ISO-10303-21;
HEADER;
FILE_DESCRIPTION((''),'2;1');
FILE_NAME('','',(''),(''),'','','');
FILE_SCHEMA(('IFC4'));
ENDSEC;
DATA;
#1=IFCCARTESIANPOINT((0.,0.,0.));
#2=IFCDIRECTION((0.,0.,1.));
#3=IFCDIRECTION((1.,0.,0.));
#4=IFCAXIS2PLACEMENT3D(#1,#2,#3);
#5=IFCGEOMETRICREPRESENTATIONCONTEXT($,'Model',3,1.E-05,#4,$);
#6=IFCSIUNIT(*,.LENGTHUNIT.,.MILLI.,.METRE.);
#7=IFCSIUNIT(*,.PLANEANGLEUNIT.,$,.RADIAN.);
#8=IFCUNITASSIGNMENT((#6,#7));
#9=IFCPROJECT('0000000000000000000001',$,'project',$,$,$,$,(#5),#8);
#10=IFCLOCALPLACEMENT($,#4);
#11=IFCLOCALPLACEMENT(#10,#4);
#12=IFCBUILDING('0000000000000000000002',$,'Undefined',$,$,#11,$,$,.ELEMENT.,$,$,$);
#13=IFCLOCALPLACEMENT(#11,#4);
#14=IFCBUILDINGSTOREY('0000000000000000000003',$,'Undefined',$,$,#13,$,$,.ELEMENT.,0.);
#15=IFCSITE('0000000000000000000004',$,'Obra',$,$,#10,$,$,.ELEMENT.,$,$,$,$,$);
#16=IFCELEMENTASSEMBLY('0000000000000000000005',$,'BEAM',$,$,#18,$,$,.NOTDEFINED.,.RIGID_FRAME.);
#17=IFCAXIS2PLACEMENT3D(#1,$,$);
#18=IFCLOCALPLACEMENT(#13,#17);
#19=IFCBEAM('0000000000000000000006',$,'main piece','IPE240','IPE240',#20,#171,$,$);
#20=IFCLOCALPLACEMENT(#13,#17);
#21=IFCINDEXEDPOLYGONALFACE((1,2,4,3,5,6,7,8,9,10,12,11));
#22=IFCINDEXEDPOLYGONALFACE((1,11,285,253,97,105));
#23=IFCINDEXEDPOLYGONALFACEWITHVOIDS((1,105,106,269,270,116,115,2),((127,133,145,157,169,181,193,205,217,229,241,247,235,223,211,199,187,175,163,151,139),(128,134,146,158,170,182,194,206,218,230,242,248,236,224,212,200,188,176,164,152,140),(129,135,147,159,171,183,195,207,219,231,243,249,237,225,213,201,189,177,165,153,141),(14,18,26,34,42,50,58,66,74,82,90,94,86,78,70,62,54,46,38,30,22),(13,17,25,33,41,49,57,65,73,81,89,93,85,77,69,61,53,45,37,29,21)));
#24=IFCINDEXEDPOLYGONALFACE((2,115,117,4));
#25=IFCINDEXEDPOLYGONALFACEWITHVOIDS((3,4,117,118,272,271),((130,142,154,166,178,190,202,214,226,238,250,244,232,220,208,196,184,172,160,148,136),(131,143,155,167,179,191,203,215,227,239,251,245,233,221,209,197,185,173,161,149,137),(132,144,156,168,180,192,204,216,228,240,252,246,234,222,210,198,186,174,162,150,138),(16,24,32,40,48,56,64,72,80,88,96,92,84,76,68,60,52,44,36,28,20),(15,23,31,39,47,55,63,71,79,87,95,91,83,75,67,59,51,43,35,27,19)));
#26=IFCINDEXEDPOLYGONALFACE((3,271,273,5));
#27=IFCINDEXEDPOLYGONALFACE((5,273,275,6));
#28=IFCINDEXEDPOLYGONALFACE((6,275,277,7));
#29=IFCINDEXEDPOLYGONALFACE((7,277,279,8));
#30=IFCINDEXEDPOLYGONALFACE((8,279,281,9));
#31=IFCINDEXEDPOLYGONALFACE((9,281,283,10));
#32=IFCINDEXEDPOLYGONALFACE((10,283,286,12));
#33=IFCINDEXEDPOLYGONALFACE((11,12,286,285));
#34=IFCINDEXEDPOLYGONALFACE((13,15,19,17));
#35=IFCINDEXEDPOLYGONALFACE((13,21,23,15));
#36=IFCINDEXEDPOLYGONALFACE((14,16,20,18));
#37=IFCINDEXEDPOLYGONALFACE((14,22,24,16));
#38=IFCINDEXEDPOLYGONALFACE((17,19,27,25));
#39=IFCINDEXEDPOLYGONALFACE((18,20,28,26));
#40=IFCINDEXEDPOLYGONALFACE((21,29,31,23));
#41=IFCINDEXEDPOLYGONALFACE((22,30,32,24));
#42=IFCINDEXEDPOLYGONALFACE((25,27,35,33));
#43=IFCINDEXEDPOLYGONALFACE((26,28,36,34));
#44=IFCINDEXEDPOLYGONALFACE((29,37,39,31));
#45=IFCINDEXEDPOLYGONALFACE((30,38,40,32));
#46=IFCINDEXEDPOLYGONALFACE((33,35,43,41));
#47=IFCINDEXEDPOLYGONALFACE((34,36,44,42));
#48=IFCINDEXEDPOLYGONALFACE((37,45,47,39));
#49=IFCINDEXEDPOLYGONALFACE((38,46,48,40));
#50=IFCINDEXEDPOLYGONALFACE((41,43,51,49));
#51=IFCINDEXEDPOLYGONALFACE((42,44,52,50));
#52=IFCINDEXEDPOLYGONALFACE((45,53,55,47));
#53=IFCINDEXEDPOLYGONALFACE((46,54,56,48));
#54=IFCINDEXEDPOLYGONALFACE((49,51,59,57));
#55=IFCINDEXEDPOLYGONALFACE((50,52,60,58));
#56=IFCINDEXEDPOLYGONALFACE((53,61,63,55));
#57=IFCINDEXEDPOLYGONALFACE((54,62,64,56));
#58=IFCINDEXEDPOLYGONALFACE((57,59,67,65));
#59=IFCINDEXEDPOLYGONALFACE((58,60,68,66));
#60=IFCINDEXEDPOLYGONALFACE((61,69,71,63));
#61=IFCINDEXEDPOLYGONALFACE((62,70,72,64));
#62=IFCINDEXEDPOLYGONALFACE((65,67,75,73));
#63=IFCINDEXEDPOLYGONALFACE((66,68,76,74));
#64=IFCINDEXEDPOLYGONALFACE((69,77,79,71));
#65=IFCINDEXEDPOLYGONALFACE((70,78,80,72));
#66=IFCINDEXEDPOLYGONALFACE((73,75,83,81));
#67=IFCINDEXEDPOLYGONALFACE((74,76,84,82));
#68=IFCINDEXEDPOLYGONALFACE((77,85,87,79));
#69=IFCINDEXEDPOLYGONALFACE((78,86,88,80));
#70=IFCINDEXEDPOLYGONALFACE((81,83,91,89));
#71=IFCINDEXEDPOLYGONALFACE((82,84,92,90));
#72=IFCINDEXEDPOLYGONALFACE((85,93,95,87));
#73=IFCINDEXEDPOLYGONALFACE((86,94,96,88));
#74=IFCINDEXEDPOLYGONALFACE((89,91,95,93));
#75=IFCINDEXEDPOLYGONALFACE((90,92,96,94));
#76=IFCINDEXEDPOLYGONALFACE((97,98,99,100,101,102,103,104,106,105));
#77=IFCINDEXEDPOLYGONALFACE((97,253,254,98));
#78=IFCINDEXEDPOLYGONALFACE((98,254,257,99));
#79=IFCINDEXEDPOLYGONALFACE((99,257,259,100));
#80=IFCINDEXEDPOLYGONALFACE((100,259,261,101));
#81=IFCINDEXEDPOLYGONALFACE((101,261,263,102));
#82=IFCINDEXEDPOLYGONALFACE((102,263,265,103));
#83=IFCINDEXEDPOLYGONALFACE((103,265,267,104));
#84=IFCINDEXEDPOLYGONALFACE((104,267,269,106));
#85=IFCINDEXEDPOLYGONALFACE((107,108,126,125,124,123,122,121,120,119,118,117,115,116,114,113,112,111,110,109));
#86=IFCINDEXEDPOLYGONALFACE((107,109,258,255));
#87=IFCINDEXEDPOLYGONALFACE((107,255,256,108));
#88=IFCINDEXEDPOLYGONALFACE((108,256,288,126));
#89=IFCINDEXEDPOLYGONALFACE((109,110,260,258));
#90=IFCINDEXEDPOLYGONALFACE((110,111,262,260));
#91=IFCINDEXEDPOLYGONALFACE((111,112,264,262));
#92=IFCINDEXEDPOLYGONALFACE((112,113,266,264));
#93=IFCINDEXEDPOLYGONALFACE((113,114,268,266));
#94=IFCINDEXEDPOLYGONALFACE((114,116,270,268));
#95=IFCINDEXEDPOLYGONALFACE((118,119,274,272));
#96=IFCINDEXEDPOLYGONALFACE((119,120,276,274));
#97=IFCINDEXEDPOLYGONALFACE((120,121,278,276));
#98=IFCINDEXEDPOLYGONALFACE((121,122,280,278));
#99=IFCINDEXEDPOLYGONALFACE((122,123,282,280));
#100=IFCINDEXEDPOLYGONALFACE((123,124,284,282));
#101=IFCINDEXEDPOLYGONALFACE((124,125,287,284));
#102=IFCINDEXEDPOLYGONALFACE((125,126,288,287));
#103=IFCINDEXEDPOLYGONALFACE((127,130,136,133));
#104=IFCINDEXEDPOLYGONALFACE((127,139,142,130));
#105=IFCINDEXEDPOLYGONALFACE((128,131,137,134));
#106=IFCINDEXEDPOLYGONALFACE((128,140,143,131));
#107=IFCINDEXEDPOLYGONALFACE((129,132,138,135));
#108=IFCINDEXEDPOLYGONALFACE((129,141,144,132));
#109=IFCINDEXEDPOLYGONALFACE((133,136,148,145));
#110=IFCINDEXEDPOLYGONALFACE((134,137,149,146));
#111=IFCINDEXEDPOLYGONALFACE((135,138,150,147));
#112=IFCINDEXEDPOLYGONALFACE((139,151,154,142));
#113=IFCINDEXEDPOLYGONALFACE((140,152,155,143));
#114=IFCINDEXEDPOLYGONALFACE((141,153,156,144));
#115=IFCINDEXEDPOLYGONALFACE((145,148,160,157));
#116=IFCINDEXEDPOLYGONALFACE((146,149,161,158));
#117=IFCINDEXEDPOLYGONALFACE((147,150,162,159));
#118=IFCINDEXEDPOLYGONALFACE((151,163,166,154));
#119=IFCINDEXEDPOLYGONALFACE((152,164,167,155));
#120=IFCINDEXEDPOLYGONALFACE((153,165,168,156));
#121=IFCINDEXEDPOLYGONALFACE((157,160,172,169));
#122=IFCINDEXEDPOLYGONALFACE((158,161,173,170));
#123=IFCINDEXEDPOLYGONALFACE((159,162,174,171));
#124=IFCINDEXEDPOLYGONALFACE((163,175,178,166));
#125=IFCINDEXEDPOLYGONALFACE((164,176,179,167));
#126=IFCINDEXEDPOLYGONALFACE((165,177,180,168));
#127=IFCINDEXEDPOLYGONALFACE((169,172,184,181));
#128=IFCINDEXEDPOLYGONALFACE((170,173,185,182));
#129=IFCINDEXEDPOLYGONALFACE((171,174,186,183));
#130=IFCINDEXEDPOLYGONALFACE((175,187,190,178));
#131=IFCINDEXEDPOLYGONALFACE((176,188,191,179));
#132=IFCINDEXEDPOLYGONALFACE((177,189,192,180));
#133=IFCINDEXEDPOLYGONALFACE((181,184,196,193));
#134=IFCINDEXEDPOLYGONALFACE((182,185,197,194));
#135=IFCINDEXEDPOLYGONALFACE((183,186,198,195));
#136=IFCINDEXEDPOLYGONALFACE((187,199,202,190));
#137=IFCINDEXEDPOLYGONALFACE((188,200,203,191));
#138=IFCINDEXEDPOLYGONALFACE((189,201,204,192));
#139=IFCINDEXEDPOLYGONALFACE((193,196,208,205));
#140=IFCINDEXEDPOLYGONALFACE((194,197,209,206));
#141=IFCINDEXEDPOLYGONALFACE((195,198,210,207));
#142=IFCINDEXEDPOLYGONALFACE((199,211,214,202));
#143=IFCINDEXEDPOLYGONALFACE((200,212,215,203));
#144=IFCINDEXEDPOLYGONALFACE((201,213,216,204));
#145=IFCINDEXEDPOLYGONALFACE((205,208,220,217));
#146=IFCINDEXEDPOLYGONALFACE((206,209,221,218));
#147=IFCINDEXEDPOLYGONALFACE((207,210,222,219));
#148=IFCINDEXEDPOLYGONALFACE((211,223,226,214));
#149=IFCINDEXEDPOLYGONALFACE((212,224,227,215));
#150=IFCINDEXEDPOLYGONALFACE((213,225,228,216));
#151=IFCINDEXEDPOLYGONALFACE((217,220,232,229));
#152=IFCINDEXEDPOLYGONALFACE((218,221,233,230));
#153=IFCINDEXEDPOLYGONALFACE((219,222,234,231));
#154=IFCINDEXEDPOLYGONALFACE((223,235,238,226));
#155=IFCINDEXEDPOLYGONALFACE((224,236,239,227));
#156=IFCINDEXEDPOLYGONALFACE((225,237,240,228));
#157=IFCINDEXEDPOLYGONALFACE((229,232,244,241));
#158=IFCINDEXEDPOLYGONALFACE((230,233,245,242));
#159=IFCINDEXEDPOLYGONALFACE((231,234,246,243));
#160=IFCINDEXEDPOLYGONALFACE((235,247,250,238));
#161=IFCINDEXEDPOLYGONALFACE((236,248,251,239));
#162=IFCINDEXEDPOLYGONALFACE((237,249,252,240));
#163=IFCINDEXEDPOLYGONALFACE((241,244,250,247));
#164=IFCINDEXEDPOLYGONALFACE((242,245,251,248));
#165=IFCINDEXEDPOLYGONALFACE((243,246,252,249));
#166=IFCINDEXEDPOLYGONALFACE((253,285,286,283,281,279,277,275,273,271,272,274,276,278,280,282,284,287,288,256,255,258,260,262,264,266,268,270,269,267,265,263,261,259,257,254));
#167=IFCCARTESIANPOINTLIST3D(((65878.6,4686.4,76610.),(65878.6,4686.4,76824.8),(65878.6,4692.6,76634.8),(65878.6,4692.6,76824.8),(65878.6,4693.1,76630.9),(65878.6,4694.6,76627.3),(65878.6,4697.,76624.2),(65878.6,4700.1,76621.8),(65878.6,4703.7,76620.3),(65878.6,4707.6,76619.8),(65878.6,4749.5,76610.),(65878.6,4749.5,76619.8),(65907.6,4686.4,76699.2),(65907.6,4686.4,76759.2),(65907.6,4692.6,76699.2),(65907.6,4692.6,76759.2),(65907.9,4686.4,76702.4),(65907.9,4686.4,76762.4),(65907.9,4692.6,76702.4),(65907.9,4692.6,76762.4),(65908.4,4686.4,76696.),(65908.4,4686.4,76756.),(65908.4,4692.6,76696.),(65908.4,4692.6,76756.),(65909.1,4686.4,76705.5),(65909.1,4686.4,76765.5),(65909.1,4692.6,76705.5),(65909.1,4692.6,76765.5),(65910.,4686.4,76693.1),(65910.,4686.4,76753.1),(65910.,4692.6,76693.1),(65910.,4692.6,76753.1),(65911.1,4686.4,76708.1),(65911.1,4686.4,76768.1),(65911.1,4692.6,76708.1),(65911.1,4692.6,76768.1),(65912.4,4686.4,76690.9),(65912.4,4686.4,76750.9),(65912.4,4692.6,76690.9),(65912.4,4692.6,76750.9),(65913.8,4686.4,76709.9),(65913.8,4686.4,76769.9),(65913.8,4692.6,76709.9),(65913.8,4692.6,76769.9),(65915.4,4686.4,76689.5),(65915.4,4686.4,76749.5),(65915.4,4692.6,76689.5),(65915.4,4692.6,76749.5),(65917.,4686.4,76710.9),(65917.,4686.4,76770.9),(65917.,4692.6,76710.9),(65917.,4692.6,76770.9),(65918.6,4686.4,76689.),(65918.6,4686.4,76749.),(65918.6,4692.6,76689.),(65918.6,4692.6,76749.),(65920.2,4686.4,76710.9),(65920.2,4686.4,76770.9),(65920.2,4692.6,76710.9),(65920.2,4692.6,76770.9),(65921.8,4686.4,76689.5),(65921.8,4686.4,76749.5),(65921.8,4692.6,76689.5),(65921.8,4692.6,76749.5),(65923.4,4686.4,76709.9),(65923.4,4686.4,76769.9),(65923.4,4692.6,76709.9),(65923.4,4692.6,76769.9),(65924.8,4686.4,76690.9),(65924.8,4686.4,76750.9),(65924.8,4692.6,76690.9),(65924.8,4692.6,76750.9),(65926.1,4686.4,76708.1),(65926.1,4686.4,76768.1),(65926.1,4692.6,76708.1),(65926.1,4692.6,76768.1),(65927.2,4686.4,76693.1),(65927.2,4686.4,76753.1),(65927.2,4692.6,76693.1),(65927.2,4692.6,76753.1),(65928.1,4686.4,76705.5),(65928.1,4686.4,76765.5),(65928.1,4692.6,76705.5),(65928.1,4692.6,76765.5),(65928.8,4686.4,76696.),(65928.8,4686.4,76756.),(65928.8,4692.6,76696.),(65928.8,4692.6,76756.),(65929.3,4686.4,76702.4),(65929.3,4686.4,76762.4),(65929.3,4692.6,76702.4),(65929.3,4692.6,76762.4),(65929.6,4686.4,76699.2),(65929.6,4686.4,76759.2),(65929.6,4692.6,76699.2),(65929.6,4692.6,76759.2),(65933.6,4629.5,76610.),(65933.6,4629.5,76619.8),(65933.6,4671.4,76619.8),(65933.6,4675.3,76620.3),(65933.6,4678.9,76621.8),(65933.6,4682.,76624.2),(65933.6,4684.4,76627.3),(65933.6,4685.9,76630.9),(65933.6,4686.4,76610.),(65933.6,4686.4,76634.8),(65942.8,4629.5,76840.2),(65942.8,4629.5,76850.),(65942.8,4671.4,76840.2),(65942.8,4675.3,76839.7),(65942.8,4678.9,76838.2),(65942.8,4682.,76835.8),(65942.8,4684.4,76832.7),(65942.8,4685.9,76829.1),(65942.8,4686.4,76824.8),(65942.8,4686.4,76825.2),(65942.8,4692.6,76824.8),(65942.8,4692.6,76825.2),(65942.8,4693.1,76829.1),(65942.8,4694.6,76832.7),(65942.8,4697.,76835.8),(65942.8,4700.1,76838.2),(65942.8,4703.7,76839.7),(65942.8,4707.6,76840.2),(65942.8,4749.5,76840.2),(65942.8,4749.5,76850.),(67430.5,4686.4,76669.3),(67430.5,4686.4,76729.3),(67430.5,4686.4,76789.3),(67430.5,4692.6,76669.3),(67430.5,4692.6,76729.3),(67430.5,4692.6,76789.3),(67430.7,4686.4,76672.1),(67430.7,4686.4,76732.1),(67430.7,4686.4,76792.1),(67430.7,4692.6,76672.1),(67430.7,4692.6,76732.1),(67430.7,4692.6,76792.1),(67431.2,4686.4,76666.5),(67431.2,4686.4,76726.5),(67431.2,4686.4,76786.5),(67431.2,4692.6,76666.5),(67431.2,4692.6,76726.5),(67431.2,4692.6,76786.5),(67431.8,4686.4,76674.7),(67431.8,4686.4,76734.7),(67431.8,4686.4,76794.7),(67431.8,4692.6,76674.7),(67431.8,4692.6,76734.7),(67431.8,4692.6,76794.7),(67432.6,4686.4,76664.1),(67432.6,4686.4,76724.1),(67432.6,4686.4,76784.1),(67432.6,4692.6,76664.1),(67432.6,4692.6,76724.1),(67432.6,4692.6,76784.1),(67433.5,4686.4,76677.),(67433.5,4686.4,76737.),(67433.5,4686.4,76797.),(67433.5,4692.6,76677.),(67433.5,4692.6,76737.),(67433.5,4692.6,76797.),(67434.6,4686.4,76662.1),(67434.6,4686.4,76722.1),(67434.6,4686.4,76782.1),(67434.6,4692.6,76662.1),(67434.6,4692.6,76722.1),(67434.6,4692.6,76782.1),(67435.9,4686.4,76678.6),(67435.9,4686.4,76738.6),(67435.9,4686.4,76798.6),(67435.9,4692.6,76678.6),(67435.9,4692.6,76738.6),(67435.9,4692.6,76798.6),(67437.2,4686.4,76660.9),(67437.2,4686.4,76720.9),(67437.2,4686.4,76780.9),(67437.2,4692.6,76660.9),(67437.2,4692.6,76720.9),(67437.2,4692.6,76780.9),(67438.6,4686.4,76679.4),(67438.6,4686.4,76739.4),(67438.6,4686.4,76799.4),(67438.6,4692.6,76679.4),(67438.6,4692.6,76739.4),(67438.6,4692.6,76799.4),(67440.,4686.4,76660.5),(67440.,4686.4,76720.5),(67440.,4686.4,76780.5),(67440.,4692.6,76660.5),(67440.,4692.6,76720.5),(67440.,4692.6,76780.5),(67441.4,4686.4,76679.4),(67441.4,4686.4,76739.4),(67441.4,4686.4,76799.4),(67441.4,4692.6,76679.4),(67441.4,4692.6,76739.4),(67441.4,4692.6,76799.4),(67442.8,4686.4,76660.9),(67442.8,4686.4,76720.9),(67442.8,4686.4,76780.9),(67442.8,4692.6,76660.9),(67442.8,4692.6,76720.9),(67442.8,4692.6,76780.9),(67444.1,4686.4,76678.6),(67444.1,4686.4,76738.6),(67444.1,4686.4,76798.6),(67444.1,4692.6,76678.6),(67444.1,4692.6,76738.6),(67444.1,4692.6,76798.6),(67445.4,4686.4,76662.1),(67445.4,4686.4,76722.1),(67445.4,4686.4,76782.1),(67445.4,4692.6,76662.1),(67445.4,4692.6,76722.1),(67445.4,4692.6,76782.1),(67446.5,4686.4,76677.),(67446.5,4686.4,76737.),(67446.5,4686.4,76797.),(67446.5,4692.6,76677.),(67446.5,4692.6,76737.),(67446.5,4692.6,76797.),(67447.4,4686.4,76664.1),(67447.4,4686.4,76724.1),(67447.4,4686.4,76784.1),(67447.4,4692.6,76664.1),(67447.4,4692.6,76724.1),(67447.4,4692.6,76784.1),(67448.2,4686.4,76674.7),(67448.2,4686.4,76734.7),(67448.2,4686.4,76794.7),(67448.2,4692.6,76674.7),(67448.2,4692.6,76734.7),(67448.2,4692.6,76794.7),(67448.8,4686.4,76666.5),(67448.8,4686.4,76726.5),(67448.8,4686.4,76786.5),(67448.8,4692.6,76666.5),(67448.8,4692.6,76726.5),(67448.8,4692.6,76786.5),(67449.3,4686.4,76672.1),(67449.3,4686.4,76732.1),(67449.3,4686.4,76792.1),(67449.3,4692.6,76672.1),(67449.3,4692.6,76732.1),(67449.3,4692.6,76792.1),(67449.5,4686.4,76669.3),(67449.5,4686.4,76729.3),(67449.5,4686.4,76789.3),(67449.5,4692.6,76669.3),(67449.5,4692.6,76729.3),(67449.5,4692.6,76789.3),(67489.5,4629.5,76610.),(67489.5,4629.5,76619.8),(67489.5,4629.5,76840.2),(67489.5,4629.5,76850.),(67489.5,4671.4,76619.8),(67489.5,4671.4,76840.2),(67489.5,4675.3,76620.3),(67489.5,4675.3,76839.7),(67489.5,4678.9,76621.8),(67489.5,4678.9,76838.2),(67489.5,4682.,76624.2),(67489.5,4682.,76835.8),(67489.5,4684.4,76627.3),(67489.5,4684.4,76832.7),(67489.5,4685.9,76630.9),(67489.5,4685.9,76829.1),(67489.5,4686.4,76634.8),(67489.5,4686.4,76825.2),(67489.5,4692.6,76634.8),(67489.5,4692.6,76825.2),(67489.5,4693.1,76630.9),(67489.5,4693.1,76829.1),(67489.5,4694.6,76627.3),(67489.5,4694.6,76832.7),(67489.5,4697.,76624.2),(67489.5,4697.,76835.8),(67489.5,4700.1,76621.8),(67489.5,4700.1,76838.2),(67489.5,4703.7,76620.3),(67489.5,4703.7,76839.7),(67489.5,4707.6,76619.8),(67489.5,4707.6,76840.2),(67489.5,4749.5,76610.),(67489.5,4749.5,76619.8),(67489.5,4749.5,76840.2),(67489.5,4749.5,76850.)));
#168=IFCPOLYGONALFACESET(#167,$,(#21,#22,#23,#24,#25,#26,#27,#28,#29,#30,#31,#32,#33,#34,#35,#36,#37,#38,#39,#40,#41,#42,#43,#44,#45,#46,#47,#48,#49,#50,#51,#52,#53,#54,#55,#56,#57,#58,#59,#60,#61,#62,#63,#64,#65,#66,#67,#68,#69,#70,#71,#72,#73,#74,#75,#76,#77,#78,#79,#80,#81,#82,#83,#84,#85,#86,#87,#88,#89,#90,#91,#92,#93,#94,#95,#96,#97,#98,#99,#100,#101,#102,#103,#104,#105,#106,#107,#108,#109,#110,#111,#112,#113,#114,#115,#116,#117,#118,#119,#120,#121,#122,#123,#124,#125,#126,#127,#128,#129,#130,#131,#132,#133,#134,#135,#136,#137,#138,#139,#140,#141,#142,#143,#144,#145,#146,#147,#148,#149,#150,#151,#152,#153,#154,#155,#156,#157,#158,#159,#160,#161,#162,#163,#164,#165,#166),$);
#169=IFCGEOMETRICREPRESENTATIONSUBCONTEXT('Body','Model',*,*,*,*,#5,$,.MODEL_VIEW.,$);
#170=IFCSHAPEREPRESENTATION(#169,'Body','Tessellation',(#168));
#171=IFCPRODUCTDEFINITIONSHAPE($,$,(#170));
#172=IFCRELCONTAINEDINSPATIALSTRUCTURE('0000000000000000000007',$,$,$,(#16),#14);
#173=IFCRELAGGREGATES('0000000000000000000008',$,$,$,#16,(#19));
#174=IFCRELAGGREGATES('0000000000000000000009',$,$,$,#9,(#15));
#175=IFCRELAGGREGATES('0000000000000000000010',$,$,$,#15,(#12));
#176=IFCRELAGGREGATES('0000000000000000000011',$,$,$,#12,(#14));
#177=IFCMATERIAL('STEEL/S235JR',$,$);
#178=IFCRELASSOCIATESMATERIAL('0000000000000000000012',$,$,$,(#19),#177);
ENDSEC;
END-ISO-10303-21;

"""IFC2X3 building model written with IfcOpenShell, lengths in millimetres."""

from ifc_helpers import new_model, si_unit, frame, origin_with_axes, origin_2d_with_axis, place, context, subcontext, project, spatial, rectangle, circle, i_section, extrude, clip, halfspace, source, transform, mapped, material, element, aggregate, save


model = new_model("IFC2X3")

# Units and contexts
model_context = context("Model", 3, precision=1e-05, world=origin_with_axes())
body_context = subcontext(model_context, "Body", "Model", "MODEL_VIEW")
ifc_project = project(units=[si_unit("LENGTHUNIT", "METRE", prefix="MILLI"), si_unit("PLANEANGLEUNIT", "RADIAN")], contexts=[model_context])

# Site, building, storey
site_placement = place(None, origin_with_axes())
site = spatial("IfcSite", under=ifc_project, at=site_placement, Name="Obra", CompositionType="ELEMENT")
building_placement = place(site_placement, origin_with_axes())
building = spatial("IfcBuilding", under=site, at=building_placement, Name="Undefined", CompositionType="ELEMENT")
storey_placement = place(building_placement, origin_with_axes())
storey = spatial("IfcBuildingStorey", under=building, at=storey_placement, Name="Undefined", CompositionType="ELEMENT", Elevation=0.0)

# Element assembly, beam, openings
ifc_material_1 = material(Name="STEEL/S235JR")
assembly_1_placement = place(storey_placement, origin_with_axes())
assembly_1 = element("IfcElementAssembly", 1, at=assembly_1_placement, inside=storey, Name="BEAM", AssemblyPlace="NOTDEFINED", PredefinedType="RIGID_FRAME")
beam_1_placement = place(assembly_1_placement, frame((65952.4, 4689.5, 76730.0), z_axis=(0.0, 0.0, 1.0), x_axis=(1.0, 0.0, 0.0)))
beam_1 = element("IfcBeam", 2, at=beam_1_placement, material=ifc_material_1, Name="main piece", Description="IPE240", ObjectType="IPE240", context=body_context, shape_type="Clipping", body=[
    clip(clip(extrude(i_section(OverallWidth=120.0, OverallDepth=240.0, WebThickness=6.2, FlangeThickness=9.8, FilletRadius=15.0, at=origin_2d_with_axis()), frame((1754.5, 0.0, 0.0), z_axis=(-1.0, 0.0, 0.0), x_axis=(0.0, -1.0, 0.0)), (0.0, 0.0, 1.0), 1828.3), halfspace(frame((1537.1, -60.0, -120.0), z_axis=(1.0, 0.000019, 0.0), x_axis=(0.0, 0.0, 1.0)), False)), halfspace(frame((-73.8, 0.0, -220.0), z_axis=(1.0, 0.0, 0.0), x_axis=(0.0, -1.0, 0.0)), True)),
])
opening_1_placement = place(assembly_1_placement, frame((65952.4, 4689.5, 76730.0), z_axis=(0.0, 0.0, 1.0), x_axis=(1.0, 0.0, 0.0)))
element("IfcOpeningElement", 3, at=opening_1_placement, cuts=beam_1, ObjectType="Recess", context=body_context, shape_type="SweptSolid", body=[
    extrude(rectangle(XDim=65.0, YDim=300.0, at=origin_2d_with_axis()), frame((-51.3, -153.1, 109.8), z_axis=(0.0, 0.0, -1.0), x_axis=(1.0, 0.0, 0.0)), (0.0, 0.0, 1.0), 249.6),
])
opening_2_placement = place(assembly_1_placement, frame((65952.4, 4689.5, 76730.0), z_axis=(0.0, 0.0, 1.0), x_axis=(1.0, 0.0, 0.0)))
element("IfcOpeningElement", 4, at=opening_2_placement, cuts=beam_1, ObjectType="Recess", context=body_context, shape_type="SweptSolid", body=[
    extrude(rectangle(XDim=26.2, YDim=76.2, at=origin_2d_with_axis()), frame((-47.7, -61.0, 107.9), z_axis=(0.0, 1.0, 0.0), x_axis=(0.0, 0.0, -1.0)), (0.0, 0.0, 1.0), 122.0),
])
shared_shape_1 = source(origin_with_axes(), body_context, "Body", "SweptSolid", [
    extrude(circle(Radius=9.5, at=origin_2d_with_axis()), frame((0.0, -3.2, 0.0), z_axis=(0.0, 1.0, 0.0), x_axis=(1.0, 0.0, 0.0)), (0.0, 0.0, 1.0), 6.4),
])
opening_3_placement = place(assembly_1_placement, frame((67490.0, 4689.5, 76850.0), z_axis=(-1.0, 0.0, 0.0), x_axis=(0.0, 0.0, -1.0)))
element("IfcOpeningElement", 5, at=opening_3_placement, cuts=beam_1, ObjectType="Opening", context=body_context, shape_type="MappedRepresentation", body=[
    mapped(shared_shape_1, transform((60.0, 0.0, 50.0))),
    mapped(shared_shape_1, transform((120.0, 0.0, 50.0))),
    mapped(shared_shape_1, transform((180.0, 0.0, 50.0))),
])
shared_shape_2 = source(origin_with_axes(), body_context, "Body", "SweptSolid", [
    extrude(circle(Radius=11.0, at=origin_2d_with_axis()), frame((0.0, -3.2, 0.0), z_axis=(0.0, 1.0, 0.0), x_axis=(1.0, 0.0, 0.0)), (0.0, 0.0, 1.0), 6.4),
])
opening_4_placement = place(assembly_1_placement, frame((65878.6, 4689.5, 76850.0), z_axis=(1.0, 0.0, 0.0), x_axis=(0.0, 0.0, -1.0)))
element("IfcOpeningElement", 6, at=opening_4_placement, cuts=beam_1, ObjectType="Opening", context=body_context, shape_type="MappedRepresentation", body=[
    mapped(shared_shape_2, transform((90.0, 0.0, 40.0))),
    mapped(shared_shape_2, transform((150.0, 0.0, 40.0))),
])

aggregate(assembly_1, [beam_1])

save(model, "model.ifc")
